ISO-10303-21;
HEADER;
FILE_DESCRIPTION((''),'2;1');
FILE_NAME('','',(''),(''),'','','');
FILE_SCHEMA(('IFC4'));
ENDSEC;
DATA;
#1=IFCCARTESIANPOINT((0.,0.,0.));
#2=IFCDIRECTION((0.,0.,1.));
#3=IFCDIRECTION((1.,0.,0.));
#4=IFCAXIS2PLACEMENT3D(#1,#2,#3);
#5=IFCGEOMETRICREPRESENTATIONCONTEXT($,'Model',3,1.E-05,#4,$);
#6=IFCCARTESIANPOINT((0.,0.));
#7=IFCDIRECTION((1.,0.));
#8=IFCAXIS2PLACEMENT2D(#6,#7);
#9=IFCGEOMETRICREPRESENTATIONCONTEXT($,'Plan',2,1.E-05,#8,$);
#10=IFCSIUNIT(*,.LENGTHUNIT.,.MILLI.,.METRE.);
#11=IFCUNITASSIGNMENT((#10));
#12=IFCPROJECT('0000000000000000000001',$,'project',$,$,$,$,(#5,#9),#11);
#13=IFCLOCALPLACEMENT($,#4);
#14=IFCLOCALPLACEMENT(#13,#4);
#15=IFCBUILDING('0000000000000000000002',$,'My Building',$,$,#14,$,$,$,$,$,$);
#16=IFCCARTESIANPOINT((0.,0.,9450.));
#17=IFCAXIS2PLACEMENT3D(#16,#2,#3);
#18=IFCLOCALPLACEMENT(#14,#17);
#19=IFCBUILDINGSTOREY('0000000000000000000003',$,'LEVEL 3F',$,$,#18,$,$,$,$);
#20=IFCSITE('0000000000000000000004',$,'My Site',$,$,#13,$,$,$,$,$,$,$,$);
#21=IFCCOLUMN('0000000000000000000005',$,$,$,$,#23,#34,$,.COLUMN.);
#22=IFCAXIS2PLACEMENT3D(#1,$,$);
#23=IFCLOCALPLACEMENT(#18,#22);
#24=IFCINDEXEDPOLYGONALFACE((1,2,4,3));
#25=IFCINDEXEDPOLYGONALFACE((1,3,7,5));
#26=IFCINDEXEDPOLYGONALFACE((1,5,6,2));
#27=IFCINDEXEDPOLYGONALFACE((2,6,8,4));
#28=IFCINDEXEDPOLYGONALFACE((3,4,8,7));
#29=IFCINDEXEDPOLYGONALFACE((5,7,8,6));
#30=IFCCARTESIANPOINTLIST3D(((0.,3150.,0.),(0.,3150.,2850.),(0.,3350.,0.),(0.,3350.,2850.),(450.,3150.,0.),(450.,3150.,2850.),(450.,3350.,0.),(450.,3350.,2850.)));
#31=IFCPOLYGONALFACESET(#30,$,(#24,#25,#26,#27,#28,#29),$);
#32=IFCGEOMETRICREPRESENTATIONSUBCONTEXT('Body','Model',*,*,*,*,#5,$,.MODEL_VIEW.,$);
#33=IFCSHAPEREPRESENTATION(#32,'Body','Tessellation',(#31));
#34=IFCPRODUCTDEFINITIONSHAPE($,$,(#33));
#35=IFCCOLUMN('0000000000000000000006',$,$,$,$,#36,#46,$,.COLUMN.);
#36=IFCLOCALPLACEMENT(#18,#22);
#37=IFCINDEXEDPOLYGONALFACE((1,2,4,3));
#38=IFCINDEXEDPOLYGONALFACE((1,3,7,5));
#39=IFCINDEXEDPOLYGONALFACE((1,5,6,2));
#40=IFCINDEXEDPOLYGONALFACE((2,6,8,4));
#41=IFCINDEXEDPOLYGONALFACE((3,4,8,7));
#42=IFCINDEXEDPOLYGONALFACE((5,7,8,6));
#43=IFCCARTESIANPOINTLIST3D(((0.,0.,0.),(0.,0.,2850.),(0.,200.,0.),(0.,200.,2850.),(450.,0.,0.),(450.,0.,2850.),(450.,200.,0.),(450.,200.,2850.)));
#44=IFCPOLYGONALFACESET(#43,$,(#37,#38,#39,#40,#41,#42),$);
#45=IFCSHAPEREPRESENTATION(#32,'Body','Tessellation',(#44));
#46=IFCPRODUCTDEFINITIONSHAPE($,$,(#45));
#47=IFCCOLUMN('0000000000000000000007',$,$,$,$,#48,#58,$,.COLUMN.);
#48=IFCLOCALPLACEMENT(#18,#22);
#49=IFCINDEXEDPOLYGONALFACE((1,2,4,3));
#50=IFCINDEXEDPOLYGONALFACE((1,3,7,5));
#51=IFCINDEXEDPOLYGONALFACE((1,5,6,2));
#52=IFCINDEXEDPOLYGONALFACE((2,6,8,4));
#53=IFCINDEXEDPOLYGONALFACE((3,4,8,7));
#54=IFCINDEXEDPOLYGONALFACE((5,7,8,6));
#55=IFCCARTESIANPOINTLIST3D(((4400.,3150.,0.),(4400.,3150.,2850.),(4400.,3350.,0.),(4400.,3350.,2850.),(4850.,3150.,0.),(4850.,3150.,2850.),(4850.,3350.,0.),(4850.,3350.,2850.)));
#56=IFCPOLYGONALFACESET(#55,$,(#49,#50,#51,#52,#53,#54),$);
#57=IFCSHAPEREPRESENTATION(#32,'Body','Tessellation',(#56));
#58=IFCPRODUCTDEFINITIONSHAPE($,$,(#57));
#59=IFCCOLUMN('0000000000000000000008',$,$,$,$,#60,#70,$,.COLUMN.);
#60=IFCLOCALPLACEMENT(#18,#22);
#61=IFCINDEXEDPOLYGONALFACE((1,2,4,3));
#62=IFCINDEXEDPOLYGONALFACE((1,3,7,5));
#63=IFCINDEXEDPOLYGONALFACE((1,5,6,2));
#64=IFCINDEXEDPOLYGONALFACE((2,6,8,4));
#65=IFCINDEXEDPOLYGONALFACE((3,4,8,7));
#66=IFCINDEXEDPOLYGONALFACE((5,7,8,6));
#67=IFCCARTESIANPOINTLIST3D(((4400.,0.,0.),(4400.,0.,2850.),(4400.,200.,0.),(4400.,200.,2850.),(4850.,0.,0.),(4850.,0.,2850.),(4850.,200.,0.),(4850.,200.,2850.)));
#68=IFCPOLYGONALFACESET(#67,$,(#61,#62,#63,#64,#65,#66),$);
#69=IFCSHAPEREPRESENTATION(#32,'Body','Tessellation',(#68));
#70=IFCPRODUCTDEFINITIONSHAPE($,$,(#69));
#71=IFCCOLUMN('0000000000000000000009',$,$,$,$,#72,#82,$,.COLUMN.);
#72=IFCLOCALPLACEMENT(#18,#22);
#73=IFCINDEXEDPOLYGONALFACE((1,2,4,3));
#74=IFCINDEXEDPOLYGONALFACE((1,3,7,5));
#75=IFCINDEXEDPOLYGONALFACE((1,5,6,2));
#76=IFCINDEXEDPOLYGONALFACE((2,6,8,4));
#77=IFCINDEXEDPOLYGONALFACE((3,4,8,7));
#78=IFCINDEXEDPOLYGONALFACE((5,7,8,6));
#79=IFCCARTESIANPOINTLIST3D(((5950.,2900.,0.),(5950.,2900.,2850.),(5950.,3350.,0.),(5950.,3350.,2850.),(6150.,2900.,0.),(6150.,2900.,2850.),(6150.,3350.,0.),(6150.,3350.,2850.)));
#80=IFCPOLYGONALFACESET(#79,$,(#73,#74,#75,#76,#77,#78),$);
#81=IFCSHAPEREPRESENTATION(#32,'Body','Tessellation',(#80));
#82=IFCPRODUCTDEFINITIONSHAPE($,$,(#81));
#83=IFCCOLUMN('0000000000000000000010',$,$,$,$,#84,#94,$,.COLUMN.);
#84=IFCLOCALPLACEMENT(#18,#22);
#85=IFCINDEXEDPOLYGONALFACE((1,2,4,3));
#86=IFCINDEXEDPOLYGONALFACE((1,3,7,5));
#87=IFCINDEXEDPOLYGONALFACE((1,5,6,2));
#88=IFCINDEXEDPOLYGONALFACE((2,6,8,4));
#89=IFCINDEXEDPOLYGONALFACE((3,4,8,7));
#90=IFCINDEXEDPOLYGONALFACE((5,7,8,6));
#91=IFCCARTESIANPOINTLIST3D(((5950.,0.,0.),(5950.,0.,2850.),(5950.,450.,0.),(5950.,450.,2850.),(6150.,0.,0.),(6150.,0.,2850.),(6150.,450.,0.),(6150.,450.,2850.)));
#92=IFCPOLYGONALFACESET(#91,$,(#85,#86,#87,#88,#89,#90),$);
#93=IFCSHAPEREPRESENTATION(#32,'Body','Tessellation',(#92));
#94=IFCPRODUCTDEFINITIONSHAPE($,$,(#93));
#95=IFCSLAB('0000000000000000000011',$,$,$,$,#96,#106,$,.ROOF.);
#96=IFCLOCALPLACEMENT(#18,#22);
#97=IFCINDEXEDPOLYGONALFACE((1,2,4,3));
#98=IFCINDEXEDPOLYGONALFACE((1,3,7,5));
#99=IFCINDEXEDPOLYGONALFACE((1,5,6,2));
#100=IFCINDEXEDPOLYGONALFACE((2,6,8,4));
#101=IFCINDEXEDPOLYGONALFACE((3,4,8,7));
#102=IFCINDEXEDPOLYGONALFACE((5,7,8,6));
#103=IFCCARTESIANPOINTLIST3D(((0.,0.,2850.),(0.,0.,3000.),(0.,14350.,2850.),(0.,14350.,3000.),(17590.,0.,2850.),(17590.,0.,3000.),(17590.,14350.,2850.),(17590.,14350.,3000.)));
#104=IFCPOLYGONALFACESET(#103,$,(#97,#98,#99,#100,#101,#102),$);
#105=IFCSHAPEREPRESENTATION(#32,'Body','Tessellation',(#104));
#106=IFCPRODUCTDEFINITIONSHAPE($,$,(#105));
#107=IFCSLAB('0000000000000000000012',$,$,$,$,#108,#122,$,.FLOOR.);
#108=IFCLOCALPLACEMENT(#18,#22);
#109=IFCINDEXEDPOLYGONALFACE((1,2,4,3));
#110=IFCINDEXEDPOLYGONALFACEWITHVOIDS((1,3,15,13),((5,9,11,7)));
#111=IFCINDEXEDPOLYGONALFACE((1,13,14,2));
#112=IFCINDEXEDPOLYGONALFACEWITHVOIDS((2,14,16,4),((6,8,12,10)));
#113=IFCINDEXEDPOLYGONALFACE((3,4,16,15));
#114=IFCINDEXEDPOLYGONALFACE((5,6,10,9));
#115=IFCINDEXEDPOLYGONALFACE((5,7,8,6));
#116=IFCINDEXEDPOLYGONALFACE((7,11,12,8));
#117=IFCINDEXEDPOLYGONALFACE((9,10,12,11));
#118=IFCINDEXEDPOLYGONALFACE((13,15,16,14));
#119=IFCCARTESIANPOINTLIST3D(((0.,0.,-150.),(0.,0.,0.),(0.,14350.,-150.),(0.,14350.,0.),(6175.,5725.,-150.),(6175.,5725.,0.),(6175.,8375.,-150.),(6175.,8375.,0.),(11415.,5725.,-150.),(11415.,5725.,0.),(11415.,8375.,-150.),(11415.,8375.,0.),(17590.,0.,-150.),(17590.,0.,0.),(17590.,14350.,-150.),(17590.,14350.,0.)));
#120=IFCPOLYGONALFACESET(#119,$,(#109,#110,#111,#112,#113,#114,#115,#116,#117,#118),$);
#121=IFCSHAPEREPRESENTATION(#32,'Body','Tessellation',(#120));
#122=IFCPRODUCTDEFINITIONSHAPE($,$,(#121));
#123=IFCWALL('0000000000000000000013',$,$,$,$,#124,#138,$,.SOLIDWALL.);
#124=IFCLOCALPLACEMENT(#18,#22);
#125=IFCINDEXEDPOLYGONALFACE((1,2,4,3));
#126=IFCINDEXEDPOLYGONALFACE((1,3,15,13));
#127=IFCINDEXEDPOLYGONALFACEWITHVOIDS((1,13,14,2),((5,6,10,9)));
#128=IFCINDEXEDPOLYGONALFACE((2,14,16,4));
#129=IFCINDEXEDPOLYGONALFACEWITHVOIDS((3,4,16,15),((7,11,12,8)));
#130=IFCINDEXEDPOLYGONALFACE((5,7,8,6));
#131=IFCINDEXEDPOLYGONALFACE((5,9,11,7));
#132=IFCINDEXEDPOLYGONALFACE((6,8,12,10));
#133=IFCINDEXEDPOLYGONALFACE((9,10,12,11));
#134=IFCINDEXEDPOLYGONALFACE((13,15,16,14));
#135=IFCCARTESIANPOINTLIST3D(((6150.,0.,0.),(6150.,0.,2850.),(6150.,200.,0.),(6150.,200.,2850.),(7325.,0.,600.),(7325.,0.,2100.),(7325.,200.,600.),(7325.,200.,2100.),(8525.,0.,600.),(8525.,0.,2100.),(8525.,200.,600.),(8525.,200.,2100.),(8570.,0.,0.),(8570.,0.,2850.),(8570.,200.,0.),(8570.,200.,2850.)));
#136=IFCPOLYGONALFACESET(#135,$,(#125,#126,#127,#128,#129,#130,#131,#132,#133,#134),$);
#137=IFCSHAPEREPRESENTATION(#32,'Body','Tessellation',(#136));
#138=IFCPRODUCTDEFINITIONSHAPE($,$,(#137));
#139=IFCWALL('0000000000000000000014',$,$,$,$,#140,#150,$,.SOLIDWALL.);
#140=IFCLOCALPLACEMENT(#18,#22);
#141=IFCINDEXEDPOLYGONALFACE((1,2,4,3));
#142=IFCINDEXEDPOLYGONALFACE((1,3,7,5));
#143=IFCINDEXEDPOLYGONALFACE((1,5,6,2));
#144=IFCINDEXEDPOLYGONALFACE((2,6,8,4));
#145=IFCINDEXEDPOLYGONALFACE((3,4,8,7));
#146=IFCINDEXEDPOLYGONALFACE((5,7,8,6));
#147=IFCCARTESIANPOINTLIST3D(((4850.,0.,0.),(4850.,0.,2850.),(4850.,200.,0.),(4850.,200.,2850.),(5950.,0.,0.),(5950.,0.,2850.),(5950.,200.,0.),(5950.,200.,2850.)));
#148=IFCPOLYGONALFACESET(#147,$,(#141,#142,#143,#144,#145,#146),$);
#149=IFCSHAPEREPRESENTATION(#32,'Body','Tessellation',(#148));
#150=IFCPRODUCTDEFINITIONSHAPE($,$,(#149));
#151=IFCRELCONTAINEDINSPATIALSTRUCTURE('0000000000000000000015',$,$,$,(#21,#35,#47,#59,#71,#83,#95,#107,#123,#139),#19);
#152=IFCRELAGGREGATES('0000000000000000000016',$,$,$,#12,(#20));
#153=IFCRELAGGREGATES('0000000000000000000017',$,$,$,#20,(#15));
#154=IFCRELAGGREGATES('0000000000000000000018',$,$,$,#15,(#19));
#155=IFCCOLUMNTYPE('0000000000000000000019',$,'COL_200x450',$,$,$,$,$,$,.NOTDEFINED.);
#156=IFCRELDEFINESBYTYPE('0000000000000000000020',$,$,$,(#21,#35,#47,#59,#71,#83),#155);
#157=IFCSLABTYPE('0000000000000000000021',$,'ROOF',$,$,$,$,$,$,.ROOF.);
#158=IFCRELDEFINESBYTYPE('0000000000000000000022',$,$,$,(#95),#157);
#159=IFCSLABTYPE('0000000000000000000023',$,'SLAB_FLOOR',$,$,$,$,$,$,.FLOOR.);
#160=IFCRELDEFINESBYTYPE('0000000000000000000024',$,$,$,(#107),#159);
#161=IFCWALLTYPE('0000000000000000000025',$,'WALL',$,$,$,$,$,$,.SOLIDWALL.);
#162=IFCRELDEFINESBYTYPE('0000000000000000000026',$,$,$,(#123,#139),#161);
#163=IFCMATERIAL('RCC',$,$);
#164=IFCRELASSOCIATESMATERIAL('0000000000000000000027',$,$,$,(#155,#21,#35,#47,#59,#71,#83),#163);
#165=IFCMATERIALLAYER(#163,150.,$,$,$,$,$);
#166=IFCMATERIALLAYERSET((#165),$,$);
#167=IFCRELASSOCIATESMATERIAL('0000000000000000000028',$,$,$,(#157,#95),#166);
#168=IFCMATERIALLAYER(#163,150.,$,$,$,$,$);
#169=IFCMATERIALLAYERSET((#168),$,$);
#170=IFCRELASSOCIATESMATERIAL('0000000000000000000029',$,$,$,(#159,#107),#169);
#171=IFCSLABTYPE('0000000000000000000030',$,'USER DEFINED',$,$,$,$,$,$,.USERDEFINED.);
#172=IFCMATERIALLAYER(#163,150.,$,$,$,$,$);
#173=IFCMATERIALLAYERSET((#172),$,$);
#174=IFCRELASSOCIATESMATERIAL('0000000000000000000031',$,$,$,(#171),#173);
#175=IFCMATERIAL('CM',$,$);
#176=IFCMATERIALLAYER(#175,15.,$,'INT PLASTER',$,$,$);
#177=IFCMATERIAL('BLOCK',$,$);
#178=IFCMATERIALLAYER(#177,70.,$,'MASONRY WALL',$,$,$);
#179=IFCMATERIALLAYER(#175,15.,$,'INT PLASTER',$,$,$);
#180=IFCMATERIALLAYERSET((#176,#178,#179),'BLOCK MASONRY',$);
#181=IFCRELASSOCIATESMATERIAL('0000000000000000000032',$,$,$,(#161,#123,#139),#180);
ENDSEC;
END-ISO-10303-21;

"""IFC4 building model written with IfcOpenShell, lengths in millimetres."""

from ifc_helpers import new_model, si_unit, frame, origin_with_axes, origin_2d_with_axis, place, context, subcontext, project, spatial, indexed_curve, rectangle, outline, extrude, material, layer, layer_set, layer_usage, material_profile, profile_set, profile_usage, type_object, element, save


model = new_model("IFC4")

# Units and contexts
model_context = context("Model", 3, precision=1e-05, world=origin_with_axes())
plan_context = context("Plan", 2, precision=1e-05, world=origin_2d_with_axis())
body_context = subcontext(model_context, "Body", "Model", "MODEL_VIEW")
ifc_project = project(units=[si_unit("LENGTHUNIT", "METRE", prefix="MILLI")], contexts=[model_context, plan_context])

# Site, building, storey
site_placement = place(None, origin_with_axes())
site = spatial("IfcSite", under=ifc_project, at=site_placement, Name="My Site")
building_placement = place(site_placement, origin_with_axes())
building = spatial("IfcBuilding", under=site, at=building_placement, Name="My Building")
storey_placement = place(building_placement, frame((0.0, 0.0, 9450.0), z_axis=(0.0, 0.0, 1.0), x_axis=(1.0, 0.0, 0.0)))
storey = spatial("IfcBuildingStorey", under=building, at=storey_placement, Name="LEVEL 3F")

# Columns
ifc_material_1 = material(Name="RCC")
ifc_material_profile = material_profile(ifc_material_1, rectangle(XDim=200.0, YDim=450.0))
ifc_profile_set = profile_set([ifc_material_profile], Name="COL_200x450")
ifc_profile_usage_1 = profile_usage(ifc_profile_set)
column_type = type_object("IfcColumnType", Name="COL_200x450", PredefinedType="NOTDEFINED", material=ifc_profile_set)
column_1_placement = place(storey_placement, frame((225.0, 3250.0, 0.0), z_axis=(0.0, 0.0, 1.0), x_axis=(0.0, -1.0, 0.0)))
element("IfcColumn", 1, at=column_1_placement, inside=storey, type_object=column_type, material=ifc_profile_usage_1, PredefinedType="COLUMN", context=body_context, shape_type="SweptSolid", body=[
    extrude(rectangle(XDim=200.0, YDim=450.0), origin_with_axes(), (0.0, 0.0, 1.0), 2850.0),
])
ifc_profile_usage_2 = profile_usage(ifc_profile_set)
column_2_placement = place(storey_placement, frame((225.0, 100.0, 0.0), z_axis=(0.0, 0.0, 1.0), x_axis=(0.0, -1.0, 0.0)))
element("IfcColumn", 2, at=column_2_placement, inside=storey, type_object=column_type, material=ifc_profile_usage_2, PredefinedType="COLUMN", context=body_context, shape_type="SweptSolid", body=[
    extrude(rectangle(XDim=200.0, YDim=450.0), origin_with_axes(), (0.0, 0.0, 1.0), 2850.0),
])
ifc_profile_usage_3 = profile_usage(ifc_profile_set)
column_3_placement = place(storey_placement, frame((4625.0, 3250.0, 0.0), z_axis=(0.0, 0.0, 1.0), x_axis=(0.0, -1.0, 0.0)))
element("IfcColumn", 3, at=column_3_placement, inside=storey, type_object=column_type, material=ifc_profile_usage_3, PredefinedType="COLUMN", context=body_context, shape_type="SweptSolid", body=[
    extrude(rectangle(XDim=200.0, YDim=450.0), origin_with_axes(), (0.0, 0.0, 1.0), 2850.0),
])
ifc_profile_usage_4 = profile_usage(ifc_profile_set)
column_4_placement = place(storey_placement, frame((4625.0, 100.0, 0.0), z_axis=(0.0, 0.0, 1.0), x_axis=(0.0, -1.0, 0.0)))
element("IfcColumn", 4, at=column_4_placement, inside=storey, type_object=column_type, material=ifc_profile_usage_4, PredefinedType="COLUMN", context=body_context, shape_type="SweptSolid", body=[
    extrude(rectangle(XDim=200.0, YDim=450.0), origin_with_axes(), (0.0, 0.0, 1.0), 2850.0),
])
ifc_profile_usage_5 = profile_usage(ifc_profile_set)
column_5_placement = place(storey_placement, frame((6050.0, 3125.0, 0.0), z_axis=(0.0, 0.0, 1.0), x_axis=(1.0, 0.0, 0.0)))
element("IfcColumn", 5, at=column_5_placement, inside=storey, type_object=column_type, material=ifc_profile_usage_5, PredefinedType="COLUMN", context=body_context, shape_type="SweptSolid", body=[
    extrude(rectangle(XDim=200.0, YDim=450.0), origin_with_axes(), (0.0, 0.0, 1.0), 2850.0),
])
ifc_profile_usage_6 = profile_usage(ifc_profile_set)
column_6_placement = place(storey_placement, frame((6050.0, 225.0, 0.0), z_axis=(0.0, 0.0, 1.0), x_axis=(1.0, 0.0, 0.0)))
element("IfcColumn", 6, at=column_6_placement, inside=storey, type_object=column_type, material=ifc_profile_usage_6, PredefinedType="COLUMN", context=body_context, shape_type="SweptSolid", body=[
    extrude(rectangle(XDim=200.0, YDim=450.0), origin_with_axes(), (0.0, 0.0, 1.0), 2850.0),
])

# Slab
ifc_layer_1 = layer(ifc_material_1, 150.0)
ifc_layer_set_1 = layer_set([ifc_layer_1])
ifc_layer_usage_1 = layer_usage(ifc_layer_set_1, "AXIS3", "POSITIVE", 0.0)
slab_type_1 = type_object("IfcSlabType", Name="ROOF", PredefinedType="ROOF", material=ifc_layer_set_1)
slab_1_placement = place(storey_placement, frame((0.0, 0.0, 2850.0), z_axis=(0.0, 0.0, 1.0), x_axis=(1.0, 0.0, 0.0)))
element("IfcSlab", 7, at=slab_1_placement, inside=storey, type_object=slab_type_1, material=ifc_layer_usage_1, PredefinedType="ROOF", context=body_context, shape_type="SweptSolid", body=[
    extrude(outline(indexed_curve([(0.0, 14350.0), (17590.0, 14350.0), (17590.0, 0.0), (0.0, 0.0)])), None, (0.0, 0.0, 1.0), 150.0),
])

# Slab, opening
ifc_layer_2 = layer(ifc_material_1, 150.0)
ifc_layer_set_2 = layer_set([ifc_layer_2])
ifc_layer_usage_2 = layer_usage(ifc_layer_set_2, "AXIS3", "POSITIVE", 0.0)
slab_type_2 = type_object("IfcSlabType", Name="SLAB_FLOOR", PredefinedType="FLOOR", material=ifc_layer_set_2)
slab_2_placement = place(storey_placement, frame((0.0, 0.0, -150.0), z_axis=(0.0, 0.0, 1.0), x_axis=(1.0, 0.0, 0.0)))
slab_2 = element("IfcSlab", 8, at=slab_2_placement, inside=storey, type_object=slab_type_2, material=ifc_layer_usage_2, PredefinedType="FLOOR", context=body_context, shape_type="SweptSolid", body=[
    extrude(outline(indexed_curve([(0.0, 14350.0), (17590.0, 14350.0), (17590.0, 0.0), (0.0, 0.0)])), None, (0.0, 0.0, 1.0), 150.0),
])
ifc_layer_3 = layer(ifc_material_1, 150.0)
ifc_layer_set_3 = layer_set([ifc_layer_3])
ifc_layer_usage_3 = layer_usage(ifc_layer_set_3, "AXIS3", "POSITIVE", 0.0)
slab_type_3 = type_object("IfcSlabType", Name="USER DEFINED", PredefinedType="USERDEFINED", material=ifc_layer_set_3)
opening_1_placement = place(slab_2_placement, origin_with_axes())
element("IfcOpeningElement", 9, at=opening_1_placement, cuts=slab_2, type_object=slab_type_3, material=ifc_layer_usage_3, ObjectType="FLOORCUTOUT", PredefinedType="OPENING", context=body_context, shape_type="SweptSolid", body=[
    extrude(outline(indexed_curve([(6175.0, 5725.0), (6175.0, 8375.0), (11415.0, 8375.0), (11415.0, 5725.0)])), None, (0.0, 0.0, 1.0), 150.0),
])

# Wall, opening
ifc_material_2 = material(Name="CM")
ifc_layer_4 = layer(ifc_material_2, 15.0, Name="INT PLASTER")
ifc_material_3 = material(Name="BLOCK")
ifc_layer_5 = layer(ifc_material_3, 70.0, Name="MASONRY WALL")
ifc_layer_6 = layer(ifc_material_2, 15.0, Name="INT PLASTER")
ifc_layer_set_4 = layer_set([ifc_layer_4, ifc_layer_5, ifc_layer_6], Name="BLOCK MASONRY")
ifc_layer_usage_4 = layer_usage(ifc_layer_set_4, "AXIS2", "POSITIVE", 0.0)
wall_type = type_object("IfcWallType", Name="WALL", PredefinedType="SOLIDWALL", material=ifc_layer_set_4)
wall_1_placement = place(storey_placement, frame((6150.0, 200.0, 0.0), z_axis=(0.0, 0.0, 1.0), x_axis=(0.0, -1.0, 0.0)))
wall_1 = element("IfcWall", 10, at=wall_1_placement, inside=storey, type_object=wall_type, material=ifc_layer_usage_4, PredefinedType="SOLIDWALL", context=body_context, shape_type="SweptSolid", body=[
    extrude(outline(indexed_curve([(0.0, 0.0), (0.0, 2420.0), (200.0, 2420.0), (200.0, 0.0), (0.0, 0.0)], self_intersect=False)), origin_with_axes(), (0.0, 0.0, 1.0), 2850.0),
])
opening_2_placement = place(wall_1_placement, frame((0.0, 2375.0, 600.0), z_axis=(0.0, 0.0, 1.0), x_axis=(0.0, -1.0, 0.0)))
element("IfcOpeningElement", 11, at=opening_2_placement, cuts=wall_1, PredefinedType="OPENING", context=body_context, shape_type="SweptSolid", body=[
    extrude(outline(indexed_curve([(0.0, 0.0), (0.0, 400.0), (1200.0, 400.0), (1200.0, 0.0), (0.0, 0.0)], self_intersect=False)), frame((0.0, -100.0, 0.0), z_axis=(0.0, 0.0, 1.0), x_axis=(1.0, 0.0, 0.0)), (0.0, 0.0, 1.0), 1500.0),
])

# Wall
ifc_layer_usage_5 = layer_usage(ifc_layer_set_4, "AXIS2", "POSITIVE", 0.0)
wall_2_placement = place(storey_placement, frame((4850.0, 200.0, 0.0), z_axis=(0.0, 0.0, 1.0), x_axis=(0.0, -1.0, 0.0)))
element("IfcWall", 12, at=wall_2_placement, inside=storey, type_object=wall_type, material=ifc_layer_usage_5, PredefinedType="SOLIDWALL", context=body_context, shape_type="SweptSolid", body=[
    extrude(outline(indexed_curve([(0.0, 0.0), (0.0, 1100.0), (200.0, 1100.0), (200.0, 0.0), (0.0, 0.0)], self_intersect=False)), origin_with_axes(), (0.0, 0.0, 1.0), 2850.0),
])

save(model, "model.ifc")
